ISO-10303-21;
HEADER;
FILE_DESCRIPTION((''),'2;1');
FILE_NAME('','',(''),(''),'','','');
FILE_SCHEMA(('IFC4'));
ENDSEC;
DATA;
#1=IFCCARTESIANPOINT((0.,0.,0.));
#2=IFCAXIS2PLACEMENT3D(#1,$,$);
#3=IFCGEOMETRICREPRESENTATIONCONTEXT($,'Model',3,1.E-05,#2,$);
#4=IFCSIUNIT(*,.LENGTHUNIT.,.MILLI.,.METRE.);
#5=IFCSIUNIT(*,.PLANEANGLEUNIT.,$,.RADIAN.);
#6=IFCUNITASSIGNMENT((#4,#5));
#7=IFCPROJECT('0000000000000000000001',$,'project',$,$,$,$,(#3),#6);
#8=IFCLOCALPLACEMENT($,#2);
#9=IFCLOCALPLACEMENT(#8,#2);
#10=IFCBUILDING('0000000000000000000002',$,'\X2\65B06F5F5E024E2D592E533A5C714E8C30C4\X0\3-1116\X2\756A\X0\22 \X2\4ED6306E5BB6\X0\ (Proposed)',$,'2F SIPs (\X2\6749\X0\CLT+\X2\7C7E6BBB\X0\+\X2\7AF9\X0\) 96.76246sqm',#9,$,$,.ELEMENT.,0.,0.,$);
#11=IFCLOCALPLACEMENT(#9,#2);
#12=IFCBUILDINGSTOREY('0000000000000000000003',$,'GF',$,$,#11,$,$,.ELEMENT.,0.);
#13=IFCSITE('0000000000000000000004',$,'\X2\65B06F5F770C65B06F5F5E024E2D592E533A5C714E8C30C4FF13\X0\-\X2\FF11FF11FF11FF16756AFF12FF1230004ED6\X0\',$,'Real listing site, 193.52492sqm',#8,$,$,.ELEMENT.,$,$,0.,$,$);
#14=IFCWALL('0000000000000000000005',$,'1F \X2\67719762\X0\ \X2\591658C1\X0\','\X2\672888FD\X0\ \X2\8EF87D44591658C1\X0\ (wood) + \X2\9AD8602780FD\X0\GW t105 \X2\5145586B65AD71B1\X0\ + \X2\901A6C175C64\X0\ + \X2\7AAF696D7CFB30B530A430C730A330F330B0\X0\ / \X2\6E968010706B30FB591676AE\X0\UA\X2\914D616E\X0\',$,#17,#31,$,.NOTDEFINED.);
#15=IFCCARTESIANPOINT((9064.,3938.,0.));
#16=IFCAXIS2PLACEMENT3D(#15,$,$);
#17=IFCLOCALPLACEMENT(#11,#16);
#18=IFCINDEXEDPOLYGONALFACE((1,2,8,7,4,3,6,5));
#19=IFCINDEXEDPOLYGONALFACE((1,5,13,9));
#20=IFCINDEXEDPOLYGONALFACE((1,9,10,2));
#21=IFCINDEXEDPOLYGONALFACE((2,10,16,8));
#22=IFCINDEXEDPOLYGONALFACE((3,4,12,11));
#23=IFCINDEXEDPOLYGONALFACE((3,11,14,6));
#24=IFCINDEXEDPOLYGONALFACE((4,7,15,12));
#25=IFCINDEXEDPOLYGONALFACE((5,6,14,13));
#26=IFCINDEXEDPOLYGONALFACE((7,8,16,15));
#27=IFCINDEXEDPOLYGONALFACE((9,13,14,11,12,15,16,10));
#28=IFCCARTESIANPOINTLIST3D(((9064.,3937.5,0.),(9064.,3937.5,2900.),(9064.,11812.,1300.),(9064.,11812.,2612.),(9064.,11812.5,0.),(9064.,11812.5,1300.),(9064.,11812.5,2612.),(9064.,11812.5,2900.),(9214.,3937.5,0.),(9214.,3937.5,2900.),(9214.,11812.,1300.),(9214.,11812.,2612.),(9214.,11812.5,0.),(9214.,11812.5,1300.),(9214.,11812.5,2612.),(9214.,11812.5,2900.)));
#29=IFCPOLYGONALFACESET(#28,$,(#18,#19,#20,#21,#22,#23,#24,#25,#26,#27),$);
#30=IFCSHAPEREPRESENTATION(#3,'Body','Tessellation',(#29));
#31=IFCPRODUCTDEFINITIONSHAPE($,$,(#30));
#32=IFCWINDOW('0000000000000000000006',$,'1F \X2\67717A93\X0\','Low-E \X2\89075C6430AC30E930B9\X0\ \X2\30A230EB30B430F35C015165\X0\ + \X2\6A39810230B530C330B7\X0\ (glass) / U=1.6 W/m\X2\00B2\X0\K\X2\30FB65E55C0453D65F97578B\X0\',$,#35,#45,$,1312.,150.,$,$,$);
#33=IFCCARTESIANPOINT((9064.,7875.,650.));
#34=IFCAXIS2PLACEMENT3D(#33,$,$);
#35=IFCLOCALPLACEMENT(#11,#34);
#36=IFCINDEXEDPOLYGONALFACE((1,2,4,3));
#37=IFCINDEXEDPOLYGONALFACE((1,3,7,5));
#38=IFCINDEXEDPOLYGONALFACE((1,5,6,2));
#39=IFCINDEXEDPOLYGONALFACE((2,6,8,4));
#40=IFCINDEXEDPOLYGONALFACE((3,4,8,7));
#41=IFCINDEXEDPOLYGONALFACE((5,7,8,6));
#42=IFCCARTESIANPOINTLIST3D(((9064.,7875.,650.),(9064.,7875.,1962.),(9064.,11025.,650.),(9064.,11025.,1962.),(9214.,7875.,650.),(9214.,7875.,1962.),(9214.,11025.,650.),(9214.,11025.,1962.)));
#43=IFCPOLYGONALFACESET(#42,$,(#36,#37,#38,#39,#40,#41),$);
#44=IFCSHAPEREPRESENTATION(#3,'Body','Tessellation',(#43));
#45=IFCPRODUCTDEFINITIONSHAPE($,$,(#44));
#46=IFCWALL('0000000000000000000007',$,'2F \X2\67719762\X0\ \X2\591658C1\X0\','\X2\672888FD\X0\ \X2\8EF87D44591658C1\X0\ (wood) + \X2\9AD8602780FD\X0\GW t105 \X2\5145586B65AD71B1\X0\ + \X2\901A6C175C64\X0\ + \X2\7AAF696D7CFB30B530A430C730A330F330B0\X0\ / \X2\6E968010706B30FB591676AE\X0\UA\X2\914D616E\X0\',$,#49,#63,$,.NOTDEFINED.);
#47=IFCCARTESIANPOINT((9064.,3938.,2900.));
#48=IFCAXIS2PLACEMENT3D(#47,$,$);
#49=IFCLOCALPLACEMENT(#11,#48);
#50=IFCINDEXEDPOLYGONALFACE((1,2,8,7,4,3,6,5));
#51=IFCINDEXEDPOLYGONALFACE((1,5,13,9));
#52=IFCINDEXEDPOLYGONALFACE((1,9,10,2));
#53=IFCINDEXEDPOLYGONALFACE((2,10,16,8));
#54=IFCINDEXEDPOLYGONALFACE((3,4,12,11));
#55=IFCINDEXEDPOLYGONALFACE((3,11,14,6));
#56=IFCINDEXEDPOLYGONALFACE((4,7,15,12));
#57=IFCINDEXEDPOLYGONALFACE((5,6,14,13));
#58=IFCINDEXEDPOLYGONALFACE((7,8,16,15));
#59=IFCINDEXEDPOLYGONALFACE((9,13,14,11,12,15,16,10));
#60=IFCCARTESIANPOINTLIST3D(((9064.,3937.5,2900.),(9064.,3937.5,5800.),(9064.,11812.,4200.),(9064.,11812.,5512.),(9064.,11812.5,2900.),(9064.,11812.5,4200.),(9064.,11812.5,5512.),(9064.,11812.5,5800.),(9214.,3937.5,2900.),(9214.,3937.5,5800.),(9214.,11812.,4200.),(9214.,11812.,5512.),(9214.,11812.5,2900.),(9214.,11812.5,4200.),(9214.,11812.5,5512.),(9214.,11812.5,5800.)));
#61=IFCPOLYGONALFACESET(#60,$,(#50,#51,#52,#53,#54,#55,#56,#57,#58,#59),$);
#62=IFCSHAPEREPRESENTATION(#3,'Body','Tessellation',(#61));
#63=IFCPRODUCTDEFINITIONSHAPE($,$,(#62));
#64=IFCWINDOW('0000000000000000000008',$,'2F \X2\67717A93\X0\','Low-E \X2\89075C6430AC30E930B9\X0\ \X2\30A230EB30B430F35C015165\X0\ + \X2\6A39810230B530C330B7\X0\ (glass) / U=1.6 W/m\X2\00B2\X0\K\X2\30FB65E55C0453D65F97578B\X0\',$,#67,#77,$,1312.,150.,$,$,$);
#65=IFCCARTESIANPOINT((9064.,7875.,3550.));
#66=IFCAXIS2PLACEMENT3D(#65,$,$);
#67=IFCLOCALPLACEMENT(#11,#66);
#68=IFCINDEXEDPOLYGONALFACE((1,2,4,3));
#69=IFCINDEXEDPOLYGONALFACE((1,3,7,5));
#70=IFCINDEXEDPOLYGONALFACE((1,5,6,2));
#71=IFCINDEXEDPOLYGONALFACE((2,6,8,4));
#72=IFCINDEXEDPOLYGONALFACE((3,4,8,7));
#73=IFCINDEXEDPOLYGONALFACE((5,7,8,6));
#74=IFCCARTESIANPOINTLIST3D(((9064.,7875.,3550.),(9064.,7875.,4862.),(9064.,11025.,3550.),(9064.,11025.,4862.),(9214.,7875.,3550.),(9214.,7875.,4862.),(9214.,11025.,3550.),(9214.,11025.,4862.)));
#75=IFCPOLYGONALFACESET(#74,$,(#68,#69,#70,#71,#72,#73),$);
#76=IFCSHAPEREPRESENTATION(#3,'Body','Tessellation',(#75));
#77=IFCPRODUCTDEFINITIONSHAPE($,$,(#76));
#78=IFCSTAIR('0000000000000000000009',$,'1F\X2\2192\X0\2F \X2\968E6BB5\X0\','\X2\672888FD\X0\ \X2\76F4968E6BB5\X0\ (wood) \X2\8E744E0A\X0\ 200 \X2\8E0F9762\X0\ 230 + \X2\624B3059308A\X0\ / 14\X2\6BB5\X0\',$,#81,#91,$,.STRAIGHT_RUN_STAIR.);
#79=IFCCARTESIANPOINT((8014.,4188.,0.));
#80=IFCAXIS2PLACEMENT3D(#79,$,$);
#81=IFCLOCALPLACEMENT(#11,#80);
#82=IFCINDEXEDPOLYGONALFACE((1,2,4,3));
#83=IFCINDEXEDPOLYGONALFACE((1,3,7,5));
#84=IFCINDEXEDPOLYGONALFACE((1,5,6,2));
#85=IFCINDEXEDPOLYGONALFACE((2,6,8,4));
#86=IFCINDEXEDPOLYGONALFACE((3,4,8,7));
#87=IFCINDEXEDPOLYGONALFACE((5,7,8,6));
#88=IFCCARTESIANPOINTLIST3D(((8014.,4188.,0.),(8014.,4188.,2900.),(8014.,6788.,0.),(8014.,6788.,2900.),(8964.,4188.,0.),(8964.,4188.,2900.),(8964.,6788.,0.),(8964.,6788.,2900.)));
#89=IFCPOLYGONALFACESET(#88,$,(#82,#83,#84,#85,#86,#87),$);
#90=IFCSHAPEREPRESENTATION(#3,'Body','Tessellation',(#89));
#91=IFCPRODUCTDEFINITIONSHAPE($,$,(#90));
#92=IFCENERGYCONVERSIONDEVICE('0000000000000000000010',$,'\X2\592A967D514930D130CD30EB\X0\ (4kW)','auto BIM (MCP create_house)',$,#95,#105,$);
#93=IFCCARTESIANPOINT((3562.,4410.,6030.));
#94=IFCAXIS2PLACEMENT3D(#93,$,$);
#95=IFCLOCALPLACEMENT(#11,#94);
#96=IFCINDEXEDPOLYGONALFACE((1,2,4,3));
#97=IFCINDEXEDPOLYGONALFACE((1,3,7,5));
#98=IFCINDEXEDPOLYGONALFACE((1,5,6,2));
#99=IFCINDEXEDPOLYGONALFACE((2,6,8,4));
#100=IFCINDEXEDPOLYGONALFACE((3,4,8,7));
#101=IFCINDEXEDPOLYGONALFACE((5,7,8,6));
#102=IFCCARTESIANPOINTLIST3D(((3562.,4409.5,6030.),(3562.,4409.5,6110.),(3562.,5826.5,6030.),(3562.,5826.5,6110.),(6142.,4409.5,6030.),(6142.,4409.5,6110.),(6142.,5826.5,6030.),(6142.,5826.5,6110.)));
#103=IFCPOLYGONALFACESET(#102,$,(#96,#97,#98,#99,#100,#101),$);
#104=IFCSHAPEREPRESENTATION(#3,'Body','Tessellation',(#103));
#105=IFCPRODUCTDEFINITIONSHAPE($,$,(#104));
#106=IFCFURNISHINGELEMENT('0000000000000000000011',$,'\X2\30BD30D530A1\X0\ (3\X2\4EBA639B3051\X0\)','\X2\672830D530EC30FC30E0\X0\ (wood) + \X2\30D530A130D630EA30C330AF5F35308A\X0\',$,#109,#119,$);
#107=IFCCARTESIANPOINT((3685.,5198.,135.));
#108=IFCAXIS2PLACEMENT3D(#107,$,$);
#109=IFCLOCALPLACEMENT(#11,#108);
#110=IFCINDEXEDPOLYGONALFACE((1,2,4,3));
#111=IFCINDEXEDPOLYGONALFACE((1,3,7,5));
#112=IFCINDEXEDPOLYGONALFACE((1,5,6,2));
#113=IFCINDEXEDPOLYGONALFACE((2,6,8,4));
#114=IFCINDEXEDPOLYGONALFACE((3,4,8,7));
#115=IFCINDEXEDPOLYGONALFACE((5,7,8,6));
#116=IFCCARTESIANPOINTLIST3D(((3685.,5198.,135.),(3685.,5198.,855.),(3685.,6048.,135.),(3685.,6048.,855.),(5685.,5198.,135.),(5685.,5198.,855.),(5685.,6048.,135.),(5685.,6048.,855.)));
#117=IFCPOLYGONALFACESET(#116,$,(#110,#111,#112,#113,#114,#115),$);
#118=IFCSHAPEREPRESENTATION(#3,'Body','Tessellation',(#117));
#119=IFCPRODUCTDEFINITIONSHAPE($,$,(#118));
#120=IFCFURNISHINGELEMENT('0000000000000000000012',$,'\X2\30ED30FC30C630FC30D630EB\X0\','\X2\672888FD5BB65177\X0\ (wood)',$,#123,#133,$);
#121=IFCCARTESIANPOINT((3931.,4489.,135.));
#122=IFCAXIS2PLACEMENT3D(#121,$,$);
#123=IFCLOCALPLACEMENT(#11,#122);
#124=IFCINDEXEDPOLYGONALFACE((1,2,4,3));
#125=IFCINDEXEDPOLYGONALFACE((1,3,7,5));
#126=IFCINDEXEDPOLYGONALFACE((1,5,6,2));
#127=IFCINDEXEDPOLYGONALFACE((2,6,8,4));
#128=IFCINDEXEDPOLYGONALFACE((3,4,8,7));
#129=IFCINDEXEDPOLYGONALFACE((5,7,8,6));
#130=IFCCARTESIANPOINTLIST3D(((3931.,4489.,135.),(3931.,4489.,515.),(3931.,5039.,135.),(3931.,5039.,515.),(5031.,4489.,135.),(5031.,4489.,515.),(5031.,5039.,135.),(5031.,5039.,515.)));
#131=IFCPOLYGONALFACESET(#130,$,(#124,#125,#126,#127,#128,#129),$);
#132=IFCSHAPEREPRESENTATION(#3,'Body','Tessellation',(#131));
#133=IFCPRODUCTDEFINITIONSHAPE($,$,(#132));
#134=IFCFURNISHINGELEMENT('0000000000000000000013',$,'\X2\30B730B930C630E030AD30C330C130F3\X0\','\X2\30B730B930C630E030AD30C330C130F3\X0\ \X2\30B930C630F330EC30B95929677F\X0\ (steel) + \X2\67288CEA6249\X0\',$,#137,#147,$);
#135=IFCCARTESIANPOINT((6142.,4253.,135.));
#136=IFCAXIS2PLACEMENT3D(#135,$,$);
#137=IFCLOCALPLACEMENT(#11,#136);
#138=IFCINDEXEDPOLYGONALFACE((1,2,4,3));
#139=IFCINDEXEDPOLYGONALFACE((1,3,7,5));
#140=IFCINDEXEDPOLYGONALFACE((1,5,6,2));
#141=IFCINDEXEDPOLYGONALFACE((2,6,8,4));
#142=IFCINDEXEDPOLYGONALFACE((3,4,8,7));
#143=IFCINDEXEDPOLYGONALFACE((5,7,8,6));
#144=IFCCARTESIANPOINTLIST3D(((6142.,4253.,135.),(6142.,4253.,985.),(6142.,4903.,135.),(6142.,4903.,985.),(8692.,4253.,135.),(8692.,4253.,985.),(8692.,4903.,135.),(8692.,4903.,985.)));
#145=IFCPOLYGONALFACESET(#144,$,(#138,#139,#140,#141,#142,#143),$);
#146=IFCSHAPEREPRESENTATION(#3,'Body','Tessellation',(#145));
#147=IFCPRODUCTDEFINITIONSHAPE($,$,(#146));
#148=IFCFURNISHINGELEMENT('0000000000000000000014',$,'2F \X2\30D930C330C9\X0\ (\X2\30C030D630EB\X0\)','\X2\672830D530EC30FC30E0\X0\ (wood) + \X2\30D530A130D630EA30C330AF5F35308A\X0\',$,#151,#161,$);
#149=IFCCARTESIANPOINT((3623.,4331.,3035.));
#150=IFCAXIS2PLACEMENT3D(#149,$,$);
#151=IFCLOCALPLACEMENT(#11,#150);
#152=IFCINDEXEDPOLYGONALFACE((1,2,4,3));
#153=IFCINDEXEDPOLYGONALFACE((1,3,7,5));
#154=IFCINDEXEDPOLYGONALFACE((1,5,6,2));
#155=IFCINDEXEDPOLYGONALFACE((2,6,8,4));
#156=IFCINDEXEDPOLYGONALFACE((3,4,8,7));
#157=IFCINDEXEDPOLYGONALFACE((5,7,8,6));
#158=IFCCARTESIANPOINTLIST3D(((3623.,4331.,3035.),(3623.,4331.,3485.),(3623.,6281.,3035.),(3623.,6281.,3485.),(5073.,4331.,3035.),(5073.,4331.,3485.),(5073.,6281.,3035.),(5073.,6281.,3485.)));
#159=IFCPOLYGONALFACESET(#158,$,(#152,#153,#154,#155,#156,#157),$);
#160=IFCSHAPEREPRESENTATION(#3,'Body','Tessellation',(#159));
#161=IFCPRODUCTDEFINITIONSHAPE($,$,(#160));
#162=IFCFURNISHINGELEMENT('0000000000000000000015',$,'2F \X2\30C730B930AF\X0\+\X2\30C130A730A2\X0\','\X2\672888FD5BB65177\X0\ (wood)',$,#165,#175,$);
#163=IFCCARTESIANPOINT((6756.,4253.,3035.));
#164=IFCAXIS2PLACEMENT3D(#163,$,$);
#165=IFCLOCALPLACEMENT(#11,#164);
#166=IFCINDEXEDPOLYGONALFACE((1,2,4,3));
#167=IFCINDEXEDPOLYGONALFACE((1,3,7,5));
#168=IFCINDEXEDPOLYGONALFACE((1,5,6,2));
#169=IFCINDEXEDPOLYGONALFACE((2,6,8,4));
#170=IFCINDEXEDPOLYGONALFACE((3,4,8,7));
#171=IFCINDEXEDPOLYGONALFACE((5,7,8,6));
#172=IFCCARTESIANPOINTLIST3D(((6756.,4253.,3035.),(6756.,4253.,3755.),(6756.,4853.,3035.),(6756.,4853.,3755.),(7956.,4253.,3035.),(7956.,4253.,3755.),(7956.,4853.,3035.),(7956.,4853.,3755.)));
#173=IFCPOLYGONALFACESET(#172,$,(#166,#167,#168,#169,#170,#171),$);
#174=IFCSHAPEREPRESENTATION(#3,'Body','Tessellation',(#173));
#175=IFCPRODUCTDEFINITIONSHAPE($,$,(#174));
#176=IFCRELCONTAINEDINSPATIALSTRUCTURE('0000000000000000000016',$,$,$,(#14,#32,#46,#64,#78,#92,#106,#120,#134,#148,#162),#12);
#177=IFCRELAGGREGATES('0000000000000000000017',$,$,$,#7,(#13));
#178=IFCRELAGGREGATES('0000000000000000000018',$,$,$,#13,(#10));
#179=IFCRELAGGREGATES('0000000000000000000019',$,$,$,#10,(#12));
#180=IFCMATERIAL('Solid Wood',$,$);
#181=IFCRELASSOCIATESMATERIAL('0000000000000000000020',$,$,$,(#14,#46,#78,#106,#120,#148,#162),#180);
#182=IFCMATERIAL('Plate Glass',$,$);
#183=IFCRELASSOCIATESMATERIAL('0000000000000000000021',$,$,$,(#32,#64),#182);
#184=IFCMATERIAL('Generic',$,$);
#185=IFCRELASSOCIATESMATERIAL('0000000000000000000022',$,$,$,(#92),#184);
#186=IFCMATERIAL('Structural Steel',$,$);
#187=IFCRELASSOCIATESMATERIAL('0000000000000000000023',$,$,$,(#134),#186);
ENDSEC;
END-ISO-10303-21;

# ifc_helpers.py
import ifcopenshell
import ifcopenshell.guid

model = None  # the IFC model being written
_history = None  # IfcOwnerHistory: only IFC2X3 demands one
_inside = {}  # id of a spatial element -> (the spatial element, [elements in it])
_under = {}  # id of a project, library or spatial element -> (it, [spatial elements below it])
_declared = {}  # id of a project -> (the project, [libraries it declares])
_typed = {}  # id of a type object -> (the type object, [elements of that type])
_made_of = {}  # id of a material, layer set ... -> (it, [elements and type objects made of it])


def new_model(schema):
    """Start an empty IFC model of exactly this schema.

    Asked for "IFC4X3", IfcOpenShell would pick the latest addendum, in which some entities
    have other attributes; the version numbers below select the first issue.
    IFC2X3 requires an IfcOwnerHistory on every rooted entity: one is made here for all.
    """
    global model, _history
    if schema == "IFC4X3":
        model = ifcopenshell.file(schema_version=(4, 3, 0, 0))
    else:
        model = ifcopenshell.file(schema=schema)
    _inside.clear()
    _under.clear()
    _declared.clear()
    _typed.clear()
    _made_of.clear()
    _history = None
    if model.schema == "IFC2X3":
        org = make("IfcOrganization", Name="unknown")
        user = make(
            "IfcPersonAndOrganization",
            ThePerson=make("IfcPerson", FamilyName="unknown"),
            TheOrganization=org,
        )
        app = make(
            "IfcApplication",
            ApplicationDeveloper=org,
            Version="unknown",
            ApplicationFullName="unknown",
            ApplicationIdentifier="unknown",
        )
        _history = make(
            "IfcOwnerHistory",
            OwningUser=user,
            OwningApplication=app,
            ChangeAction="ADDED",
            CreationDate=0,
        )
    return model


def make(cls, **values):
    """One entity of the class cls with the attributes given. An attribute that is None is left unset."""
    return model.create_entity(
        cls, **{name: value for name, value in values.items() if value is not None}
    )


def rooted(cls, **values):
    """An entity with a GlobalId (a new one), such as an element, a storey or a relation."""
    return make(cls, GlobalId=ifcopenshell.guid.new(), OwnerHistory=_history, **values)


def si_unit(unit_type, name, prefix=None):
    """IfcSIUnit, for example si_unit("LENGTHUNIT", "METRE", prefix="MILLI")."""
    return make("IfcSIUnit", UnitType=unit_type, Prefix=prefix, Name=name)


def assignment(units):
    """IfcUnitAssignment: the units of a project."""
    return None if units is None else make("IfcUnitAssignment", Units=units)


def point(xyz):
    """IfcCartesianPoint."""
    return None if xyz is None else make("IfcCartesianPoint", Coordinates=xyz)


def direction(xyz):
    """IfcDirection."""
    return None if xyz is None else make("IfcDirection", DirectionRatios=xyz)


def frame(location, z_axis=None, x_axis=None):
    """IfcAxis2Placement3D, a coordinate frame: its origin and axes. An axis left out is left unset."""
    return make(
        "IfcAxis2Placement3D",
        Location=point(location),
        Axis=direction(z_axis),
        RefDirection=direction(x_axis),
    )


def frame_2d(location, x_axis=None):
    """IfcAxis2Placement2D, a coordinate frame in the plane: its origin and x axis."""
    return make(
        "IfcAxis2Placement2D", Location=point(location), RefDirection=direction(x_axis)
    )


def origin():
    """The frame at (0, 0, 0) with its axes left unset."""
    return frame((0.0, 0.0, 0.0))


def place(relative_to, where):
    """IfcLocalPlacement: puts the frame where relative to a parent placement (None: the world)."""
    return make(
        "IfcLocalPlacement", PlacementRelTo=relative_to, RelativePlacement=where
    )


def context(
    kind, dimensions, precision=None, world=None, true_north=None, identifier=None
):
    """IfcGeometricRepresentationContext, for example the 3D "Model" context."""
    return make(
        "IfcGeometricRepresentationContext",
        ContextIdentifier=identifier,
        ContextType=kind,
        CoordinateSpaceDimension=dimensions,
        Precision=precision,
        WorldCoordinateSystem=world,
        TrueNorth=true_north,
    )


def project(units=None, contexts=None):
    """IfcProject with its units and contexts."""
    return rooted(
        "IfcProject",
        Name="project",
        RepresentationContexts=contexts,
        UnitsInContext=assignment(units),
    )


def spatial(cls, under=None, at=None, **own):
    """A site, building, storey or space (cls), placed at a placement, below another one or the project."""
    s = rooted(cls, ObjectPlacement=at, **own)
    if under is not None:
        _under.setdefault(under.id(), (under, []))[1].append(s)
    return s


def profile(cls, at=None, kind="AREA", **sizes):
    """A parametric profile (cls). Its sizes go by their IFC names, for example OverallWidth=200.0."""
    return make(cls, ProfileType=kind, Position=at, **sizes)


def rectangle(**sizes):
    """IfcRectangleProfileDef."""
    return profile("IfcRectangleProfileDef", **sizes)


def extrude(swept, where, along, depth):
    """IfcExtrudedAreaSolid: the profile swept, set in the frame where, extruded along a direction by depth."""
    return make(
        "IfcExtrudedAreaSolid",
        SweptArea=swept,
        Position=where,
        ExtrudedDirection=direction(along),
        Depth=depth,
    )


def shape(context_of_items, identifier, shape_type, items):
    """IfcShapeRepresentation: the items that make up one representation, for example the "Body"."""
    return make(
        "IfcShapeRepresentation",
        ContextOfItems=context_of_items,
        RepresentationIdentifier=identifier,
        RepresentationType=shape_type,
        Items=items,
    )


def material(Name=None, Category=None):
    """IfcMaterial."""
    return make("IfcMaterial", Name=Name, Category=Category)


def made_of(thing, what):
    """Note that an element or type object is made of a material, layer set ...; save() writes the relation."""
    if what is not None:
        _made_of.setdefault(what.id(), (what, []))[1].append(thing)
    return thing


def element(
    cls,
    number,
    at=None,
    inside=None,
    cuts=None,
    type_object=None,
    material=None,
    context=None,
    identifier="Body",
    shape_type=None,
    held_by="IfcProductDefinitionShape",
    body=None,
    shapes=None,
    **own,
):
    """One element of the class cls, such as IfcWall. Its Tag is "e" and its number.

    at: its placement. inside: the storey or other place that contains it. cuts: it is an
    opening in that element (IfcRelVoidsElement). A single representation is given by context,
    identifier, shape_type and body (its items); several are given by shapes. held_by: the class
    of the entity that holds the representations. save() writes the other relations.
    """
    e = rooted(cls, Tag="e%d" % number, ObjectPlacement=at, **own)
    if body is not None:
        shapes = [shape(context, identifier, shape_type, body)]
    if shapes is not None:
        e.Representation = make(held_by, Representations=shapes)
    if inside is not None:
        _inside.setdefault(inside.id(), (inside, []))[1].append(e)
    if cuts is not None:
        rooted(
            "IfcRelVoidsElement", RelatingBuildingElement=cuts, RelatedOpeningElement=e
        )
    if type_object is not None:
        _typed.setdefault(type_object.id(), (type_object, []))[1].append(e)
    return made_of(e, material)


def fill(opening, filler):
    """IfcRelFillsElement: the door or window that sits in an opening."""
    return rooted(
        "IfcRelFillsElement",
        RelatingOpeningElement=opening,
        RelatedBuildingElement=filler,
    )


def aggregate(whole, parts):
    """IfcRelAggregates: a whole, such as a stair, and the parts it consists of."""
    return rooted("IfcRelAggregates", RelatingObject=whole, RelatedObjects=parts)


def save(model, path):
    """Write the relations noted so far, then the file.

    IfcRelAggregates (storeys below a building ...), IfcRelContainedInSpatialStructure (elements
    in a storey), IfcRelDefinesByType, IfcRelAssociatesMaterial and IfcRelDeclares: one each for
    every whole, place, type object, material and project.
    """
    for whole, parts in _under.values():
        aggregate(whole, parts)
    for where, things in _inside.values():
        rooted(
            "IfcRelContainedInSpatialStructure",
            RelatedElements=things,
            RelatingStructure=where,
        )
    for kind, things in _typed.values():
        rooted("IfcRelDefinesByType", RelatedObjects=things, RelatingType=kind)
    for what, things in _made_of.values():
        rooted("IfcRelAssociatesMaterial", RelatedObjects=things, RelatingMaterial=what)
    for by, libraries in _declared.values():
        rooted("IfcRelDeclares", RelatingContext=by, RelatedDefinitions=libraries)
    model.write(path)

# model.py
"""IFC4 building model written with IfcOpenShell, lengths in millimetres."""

from ifc_helpers import new_model, si_unit, frame, frame_2d, origin, place, context, project, spatial, rectangle, extrude, material, element, fill, save


model = new_model("IFC4")

# Units and contexts
model_context = context("Model", 3, precision=1e-05, world=origin())
ifc_project = project(units=[si_unit("LENGTHUNIT", "METRE", prefix="MILLI"), si_unit("PLANEANGLEUNIT", "RADIAN")], contexts=[model_context])

# Site, building, storey
site_placement = place(None, origin())
site = spatial("IfcSite", under=ifc_project, at=site_placement, Name="新潟県新潟市中央区山二ツ３-１１１６番２２　他", ObjectType="Real listing site, 193.52492sqm", CompositionType="ELEMENT", RefElevation=0.0)
building_placement = place(site_placement, origin())
building = spatial("IfcBuilding", under=site, at=building_placement, Name="新潟市中央区山二ツ3-1116番22 他の家 (Proposed)", ObjectType="2F SIPs (杉CLT+籾殻+竹) 96.76246sqm", CompositionType="ELEMENT", ElevationOfRefHeight=0.0, ElevationOfTerrain=0.0)
storey_placement = place(building_placement, origin())
storey = spatial("IfcBuildingStorey", under=building, at=storey_placement, Name="GF", CompositionType="ELEMENT", Elevation=0.0)

# Wall, opening, window
ifc_material_1 = material(Name="Solid Wood")
wall_1_placement = place(storey_placement, frame((9064.0, 3938.0, 0.0)))
wall_1 = element("IfcWall", 1, at=wall_1_placement, inside=storey, material=ifc_material_1, Name="1F 東面 外壁", Description="木製 軸組外壁 (wood) + 高性能GW t105 充填断熱 + 通気層 + 窯業系サイディング / 準耐火・外皮UA配慮", PredefinedType="NOTDEFINED", context=model_context, shape_type="SweptSolid", body=[
    extrude(rectangle(XDim=150.0, YDim=7875.0, at=frame_2d((75.0, 3937.0))), frame((9064.0, 3938.0, 0.0)), (0.0, 0.0, 1.0), 2900.0),
])
opening_1_placement = place(storey_placement, frame((9064.0, 7875.0, 650.0)))
opening_1 = element("IfcOpeningElement", 2, at=opening_1_placement, cuts=wall_1, PredefinedType="NOTDEFINED", context=model_context, shape_type="SweptSolid", body=[
    extrude(rectangle(XDim=150.0, YDim=3150.0, at=frame_2d((75.0, 1575.0))), frame((9064.0, 7875.0, 650.0)), (0.0, 0.0, 1.0), 1312.0),
])
ifc_material_2 = material(Name="Plate Glass")
window_1_placement = place(storey_placement, frame((9064.0, 7875.0, 650.0)))
window_1 = element("IfcWindow", 3, at=window_1_placement, inside=storey, material=ifc_material_2, Name="1F 東窓", Description="Low-E 複層ガラス アルゴン封入 + 樹脂サッシ (glass) / U=1.6 W/m²K・日射取得型", OverallHeight=1312.0, OverallWidth=150.0, context=model_context, shape_type="SweptSolid", body=[
    extrude(rectangle(XDim=150.0, YDim=3150.0, at=frame_2d((75.0, 1575.0))), frame((9064.0, 7875.0, 650.0)), (0.0, 0.0, 1.0), 1312.0),
])
fill(opening_1, window_1)

# Wall, opening, window
wall_2_placement = place(storey_placement, frame((9064.0, 3938.0, 2900.0)))
wall_2 = element("IfcWall", 4, at=wall_2_placement, inside=storey, material=ifc_material_1, Name="2F 東面 外壁", Description="木製 軸組外壁 (wood) + 高性能GW t105 充填断熱 + 通気層 + 窯業系サイディング / 準耐火・外皮UA配慮", PredefinedType="NOTDEFINED", context=model_context, shape_type="SweptSolid", body=[
    extrude(rectangle(XDim=150.0, YDim=7875.0, at=frame_2d((75.0, 3937.0))), frame((9064.0, 3938.0, 2900.0)), (0.0, 0.0, 1.0), 2900.0),
])
opening_2_placement = place(storey_placement, frame((9064.0, 7875.0, 3550.0)))
opening_2 = element("IfcOpeningElement", 5, at=opening_2_placement, cuts=wall_2, PredefinedType="NOTDEFINED", context=model_context, shape_type="SweptSolid", body=[
    extrude(rectangle(XDim=150.0, YDim=3150.0, at=frame_2d((75.0, 1575.0))), frame((9064.0, 7875.0, 3550.0)), (0.0, 0.0, 1.0), 1312.0),
])
window_2_placement = place(storey_placement, frame((9064.0, 7875.0, 3550.0)))
window_2 = element("IfcWindow", 6, at=window_2_placement, inside=storey, material=ifc_material_2, Name="2F 東窓", Description="Low-E 複層ガラス アルゴン封入 + 樹脂サッシ (glass) / U=1.6 W/m²K・日射取得型", OverallHeight=1312.0, OverallWidth=150.0, context=model_context, shape_type="SweptSolid", body=[
    extrude(rectangle(XDim=150.0, YDim=3150.0, at=frame_2d((75.0, 1575.0))), frame((9064.0, 7875.0, 3550.0)), (0.0, 0.0, 1.0), 1312.0),
])
fill(opening_2, window_2)

# Stair
stair_placement = place(storey_placement, frame((8014.0, 4188.0, 0.0)))
element("IfcStair", 7, at=stair_placement, inside=storey, material=ifc_material_1, Name="1F→2F 階段", Description="木製 直階段 (wood) 蹴上 200 踏面 230 + 手すり / 14段", PredefinedType="STRAIGHT_RUN_STAIR", context=model_context, shape_type="SweptSolid", body=[
    extrude(rectangle(XDim=950.0, YDim=2600.0, at=frame_2d((475.0, 1300.0))), frame((8014.0, 4188.0, 0.0)), (0.0, 0.0, 1.0), 2900.0),
])

# Energy conversion device
ifc_material_3 = material(Name="Generic")
energy_conversion_device_placement = place(storey_placement, frame((3562.0, 4410.0, 6030.0)))
element("IfcEnergyConversionDevice", 8, at=energy_conversion_device_placement, inside=storey, material=ifc_material_3, Name="太陽光パネル (4kW)", Description="auto BIM (MCP create_house)", context=model_context, shape_type="SweptSolid", body=[
    extrude(rectangle(XDim=2580.0, YDim=1417.0, at=frame_2d((1290.0, 708.0))), frame((3562.0, 4410.0, 6030.0)), (0.0, 0.0, 1.0), 80.0),
])

# Furnishing elements
furnishing_1_placement = place(storey_placement, frame((3685.0, 5198.0, 135.0)))
element("IfcFurnishingElement", 9, at=furnishing_1_placement, inside=storey, material=ifc_material_1, Name="ソファ (3人掛け)", Description="木フレーム (wood) + ファブリック張り", context=model_context, shape_type="SweptSolid", body=[
    extrude(rectangle(XDim=2000.0, YDim=850.0, at=frame_2d((1000.0, 425.0))), frame((3685.0, 5198.0, 135.0)), (0.0, 0.0, 1.0), 720.0),
])
furnishing_2_placement = place(storey_placement, frame((3931.0, 4489.0, 135.0)))
element("IfcFurnishingElement", 10, at=furnishing_2_placement, inside=storey, material=ifc_material_1, Name="ローテーブル", Description="木製家具 (wood)", context=model_context, shape_type="SweptSolid", body=[
    extrude(rectangle(XDim=1100.0, YDim=550.0, at=frame_2d((550.0, 275.0))), frame((3931.0, 4489.0, 135.0)), (0.0, 0.0, 1.0), 380.0),
])
ifc_material_4 = material(Name="Structural Steel")
furnishing_3_placement = place(storey_placement, frame((6142.0, 4253.0, 135.0)))
element("IfcFurnishingElement", 11, at=furnishing_3_placement, inside=storey, material=ifc_material_4, Name="システムキッチン", Description="システムキッチン ステンレス天板 (steel) + 木質扉", context=model_context, shape_type="SweptSolid", body=[
    extrude(rectangle(XDim=2550.0, YDim=650.0, at=frame_2d((1275.0, 325.0))), frame((6142.0, 4253.0, 135.0)), (0.0, 0.0, 1.0), 850.0),
])
furnishing_4_placement = place(storey_placement, frame((3623.0, 4331.0, 3035.0)))
element("IfcFurnishingElement", 12, at=furnishing_4_placement, inside=storey, material=ifc_material_1, Name="2F ベッド (ダブル)", Description="木フレーム (wood) + ファブリック張り", context=model_context, shape_type="SweptSolid", body=[
    extrude(rectangle(XDim=1450.0, YDim=1950.0, at=frame_2d((725.0, 975.0))), frame((3623.0, 4331.0, 3035.0)), (0.0, 0.0, 1.0), 450.0),
])
furnishing_5_placement = place(storey_placement, frame((6756.0, 4253.0, 3035.0)))
element("IfcFurnishingElement", 13, at=furnishing_5_placement, inside=storey, material=ifc_material_1, Name="2F デスク+チェア", Description="木製家具 (wood)", context=model_context, shape_type="SweptSolid", body=[
    extrude(rectangle(XDim=1200.0, YDim=600.0, at=frame_2d((600.0, 300.0))), frame((6756.0, 4253.0, 3035.0)), (0.0, 0.0, 1.0), 720.0),
])

save(model, "model.ifc")
